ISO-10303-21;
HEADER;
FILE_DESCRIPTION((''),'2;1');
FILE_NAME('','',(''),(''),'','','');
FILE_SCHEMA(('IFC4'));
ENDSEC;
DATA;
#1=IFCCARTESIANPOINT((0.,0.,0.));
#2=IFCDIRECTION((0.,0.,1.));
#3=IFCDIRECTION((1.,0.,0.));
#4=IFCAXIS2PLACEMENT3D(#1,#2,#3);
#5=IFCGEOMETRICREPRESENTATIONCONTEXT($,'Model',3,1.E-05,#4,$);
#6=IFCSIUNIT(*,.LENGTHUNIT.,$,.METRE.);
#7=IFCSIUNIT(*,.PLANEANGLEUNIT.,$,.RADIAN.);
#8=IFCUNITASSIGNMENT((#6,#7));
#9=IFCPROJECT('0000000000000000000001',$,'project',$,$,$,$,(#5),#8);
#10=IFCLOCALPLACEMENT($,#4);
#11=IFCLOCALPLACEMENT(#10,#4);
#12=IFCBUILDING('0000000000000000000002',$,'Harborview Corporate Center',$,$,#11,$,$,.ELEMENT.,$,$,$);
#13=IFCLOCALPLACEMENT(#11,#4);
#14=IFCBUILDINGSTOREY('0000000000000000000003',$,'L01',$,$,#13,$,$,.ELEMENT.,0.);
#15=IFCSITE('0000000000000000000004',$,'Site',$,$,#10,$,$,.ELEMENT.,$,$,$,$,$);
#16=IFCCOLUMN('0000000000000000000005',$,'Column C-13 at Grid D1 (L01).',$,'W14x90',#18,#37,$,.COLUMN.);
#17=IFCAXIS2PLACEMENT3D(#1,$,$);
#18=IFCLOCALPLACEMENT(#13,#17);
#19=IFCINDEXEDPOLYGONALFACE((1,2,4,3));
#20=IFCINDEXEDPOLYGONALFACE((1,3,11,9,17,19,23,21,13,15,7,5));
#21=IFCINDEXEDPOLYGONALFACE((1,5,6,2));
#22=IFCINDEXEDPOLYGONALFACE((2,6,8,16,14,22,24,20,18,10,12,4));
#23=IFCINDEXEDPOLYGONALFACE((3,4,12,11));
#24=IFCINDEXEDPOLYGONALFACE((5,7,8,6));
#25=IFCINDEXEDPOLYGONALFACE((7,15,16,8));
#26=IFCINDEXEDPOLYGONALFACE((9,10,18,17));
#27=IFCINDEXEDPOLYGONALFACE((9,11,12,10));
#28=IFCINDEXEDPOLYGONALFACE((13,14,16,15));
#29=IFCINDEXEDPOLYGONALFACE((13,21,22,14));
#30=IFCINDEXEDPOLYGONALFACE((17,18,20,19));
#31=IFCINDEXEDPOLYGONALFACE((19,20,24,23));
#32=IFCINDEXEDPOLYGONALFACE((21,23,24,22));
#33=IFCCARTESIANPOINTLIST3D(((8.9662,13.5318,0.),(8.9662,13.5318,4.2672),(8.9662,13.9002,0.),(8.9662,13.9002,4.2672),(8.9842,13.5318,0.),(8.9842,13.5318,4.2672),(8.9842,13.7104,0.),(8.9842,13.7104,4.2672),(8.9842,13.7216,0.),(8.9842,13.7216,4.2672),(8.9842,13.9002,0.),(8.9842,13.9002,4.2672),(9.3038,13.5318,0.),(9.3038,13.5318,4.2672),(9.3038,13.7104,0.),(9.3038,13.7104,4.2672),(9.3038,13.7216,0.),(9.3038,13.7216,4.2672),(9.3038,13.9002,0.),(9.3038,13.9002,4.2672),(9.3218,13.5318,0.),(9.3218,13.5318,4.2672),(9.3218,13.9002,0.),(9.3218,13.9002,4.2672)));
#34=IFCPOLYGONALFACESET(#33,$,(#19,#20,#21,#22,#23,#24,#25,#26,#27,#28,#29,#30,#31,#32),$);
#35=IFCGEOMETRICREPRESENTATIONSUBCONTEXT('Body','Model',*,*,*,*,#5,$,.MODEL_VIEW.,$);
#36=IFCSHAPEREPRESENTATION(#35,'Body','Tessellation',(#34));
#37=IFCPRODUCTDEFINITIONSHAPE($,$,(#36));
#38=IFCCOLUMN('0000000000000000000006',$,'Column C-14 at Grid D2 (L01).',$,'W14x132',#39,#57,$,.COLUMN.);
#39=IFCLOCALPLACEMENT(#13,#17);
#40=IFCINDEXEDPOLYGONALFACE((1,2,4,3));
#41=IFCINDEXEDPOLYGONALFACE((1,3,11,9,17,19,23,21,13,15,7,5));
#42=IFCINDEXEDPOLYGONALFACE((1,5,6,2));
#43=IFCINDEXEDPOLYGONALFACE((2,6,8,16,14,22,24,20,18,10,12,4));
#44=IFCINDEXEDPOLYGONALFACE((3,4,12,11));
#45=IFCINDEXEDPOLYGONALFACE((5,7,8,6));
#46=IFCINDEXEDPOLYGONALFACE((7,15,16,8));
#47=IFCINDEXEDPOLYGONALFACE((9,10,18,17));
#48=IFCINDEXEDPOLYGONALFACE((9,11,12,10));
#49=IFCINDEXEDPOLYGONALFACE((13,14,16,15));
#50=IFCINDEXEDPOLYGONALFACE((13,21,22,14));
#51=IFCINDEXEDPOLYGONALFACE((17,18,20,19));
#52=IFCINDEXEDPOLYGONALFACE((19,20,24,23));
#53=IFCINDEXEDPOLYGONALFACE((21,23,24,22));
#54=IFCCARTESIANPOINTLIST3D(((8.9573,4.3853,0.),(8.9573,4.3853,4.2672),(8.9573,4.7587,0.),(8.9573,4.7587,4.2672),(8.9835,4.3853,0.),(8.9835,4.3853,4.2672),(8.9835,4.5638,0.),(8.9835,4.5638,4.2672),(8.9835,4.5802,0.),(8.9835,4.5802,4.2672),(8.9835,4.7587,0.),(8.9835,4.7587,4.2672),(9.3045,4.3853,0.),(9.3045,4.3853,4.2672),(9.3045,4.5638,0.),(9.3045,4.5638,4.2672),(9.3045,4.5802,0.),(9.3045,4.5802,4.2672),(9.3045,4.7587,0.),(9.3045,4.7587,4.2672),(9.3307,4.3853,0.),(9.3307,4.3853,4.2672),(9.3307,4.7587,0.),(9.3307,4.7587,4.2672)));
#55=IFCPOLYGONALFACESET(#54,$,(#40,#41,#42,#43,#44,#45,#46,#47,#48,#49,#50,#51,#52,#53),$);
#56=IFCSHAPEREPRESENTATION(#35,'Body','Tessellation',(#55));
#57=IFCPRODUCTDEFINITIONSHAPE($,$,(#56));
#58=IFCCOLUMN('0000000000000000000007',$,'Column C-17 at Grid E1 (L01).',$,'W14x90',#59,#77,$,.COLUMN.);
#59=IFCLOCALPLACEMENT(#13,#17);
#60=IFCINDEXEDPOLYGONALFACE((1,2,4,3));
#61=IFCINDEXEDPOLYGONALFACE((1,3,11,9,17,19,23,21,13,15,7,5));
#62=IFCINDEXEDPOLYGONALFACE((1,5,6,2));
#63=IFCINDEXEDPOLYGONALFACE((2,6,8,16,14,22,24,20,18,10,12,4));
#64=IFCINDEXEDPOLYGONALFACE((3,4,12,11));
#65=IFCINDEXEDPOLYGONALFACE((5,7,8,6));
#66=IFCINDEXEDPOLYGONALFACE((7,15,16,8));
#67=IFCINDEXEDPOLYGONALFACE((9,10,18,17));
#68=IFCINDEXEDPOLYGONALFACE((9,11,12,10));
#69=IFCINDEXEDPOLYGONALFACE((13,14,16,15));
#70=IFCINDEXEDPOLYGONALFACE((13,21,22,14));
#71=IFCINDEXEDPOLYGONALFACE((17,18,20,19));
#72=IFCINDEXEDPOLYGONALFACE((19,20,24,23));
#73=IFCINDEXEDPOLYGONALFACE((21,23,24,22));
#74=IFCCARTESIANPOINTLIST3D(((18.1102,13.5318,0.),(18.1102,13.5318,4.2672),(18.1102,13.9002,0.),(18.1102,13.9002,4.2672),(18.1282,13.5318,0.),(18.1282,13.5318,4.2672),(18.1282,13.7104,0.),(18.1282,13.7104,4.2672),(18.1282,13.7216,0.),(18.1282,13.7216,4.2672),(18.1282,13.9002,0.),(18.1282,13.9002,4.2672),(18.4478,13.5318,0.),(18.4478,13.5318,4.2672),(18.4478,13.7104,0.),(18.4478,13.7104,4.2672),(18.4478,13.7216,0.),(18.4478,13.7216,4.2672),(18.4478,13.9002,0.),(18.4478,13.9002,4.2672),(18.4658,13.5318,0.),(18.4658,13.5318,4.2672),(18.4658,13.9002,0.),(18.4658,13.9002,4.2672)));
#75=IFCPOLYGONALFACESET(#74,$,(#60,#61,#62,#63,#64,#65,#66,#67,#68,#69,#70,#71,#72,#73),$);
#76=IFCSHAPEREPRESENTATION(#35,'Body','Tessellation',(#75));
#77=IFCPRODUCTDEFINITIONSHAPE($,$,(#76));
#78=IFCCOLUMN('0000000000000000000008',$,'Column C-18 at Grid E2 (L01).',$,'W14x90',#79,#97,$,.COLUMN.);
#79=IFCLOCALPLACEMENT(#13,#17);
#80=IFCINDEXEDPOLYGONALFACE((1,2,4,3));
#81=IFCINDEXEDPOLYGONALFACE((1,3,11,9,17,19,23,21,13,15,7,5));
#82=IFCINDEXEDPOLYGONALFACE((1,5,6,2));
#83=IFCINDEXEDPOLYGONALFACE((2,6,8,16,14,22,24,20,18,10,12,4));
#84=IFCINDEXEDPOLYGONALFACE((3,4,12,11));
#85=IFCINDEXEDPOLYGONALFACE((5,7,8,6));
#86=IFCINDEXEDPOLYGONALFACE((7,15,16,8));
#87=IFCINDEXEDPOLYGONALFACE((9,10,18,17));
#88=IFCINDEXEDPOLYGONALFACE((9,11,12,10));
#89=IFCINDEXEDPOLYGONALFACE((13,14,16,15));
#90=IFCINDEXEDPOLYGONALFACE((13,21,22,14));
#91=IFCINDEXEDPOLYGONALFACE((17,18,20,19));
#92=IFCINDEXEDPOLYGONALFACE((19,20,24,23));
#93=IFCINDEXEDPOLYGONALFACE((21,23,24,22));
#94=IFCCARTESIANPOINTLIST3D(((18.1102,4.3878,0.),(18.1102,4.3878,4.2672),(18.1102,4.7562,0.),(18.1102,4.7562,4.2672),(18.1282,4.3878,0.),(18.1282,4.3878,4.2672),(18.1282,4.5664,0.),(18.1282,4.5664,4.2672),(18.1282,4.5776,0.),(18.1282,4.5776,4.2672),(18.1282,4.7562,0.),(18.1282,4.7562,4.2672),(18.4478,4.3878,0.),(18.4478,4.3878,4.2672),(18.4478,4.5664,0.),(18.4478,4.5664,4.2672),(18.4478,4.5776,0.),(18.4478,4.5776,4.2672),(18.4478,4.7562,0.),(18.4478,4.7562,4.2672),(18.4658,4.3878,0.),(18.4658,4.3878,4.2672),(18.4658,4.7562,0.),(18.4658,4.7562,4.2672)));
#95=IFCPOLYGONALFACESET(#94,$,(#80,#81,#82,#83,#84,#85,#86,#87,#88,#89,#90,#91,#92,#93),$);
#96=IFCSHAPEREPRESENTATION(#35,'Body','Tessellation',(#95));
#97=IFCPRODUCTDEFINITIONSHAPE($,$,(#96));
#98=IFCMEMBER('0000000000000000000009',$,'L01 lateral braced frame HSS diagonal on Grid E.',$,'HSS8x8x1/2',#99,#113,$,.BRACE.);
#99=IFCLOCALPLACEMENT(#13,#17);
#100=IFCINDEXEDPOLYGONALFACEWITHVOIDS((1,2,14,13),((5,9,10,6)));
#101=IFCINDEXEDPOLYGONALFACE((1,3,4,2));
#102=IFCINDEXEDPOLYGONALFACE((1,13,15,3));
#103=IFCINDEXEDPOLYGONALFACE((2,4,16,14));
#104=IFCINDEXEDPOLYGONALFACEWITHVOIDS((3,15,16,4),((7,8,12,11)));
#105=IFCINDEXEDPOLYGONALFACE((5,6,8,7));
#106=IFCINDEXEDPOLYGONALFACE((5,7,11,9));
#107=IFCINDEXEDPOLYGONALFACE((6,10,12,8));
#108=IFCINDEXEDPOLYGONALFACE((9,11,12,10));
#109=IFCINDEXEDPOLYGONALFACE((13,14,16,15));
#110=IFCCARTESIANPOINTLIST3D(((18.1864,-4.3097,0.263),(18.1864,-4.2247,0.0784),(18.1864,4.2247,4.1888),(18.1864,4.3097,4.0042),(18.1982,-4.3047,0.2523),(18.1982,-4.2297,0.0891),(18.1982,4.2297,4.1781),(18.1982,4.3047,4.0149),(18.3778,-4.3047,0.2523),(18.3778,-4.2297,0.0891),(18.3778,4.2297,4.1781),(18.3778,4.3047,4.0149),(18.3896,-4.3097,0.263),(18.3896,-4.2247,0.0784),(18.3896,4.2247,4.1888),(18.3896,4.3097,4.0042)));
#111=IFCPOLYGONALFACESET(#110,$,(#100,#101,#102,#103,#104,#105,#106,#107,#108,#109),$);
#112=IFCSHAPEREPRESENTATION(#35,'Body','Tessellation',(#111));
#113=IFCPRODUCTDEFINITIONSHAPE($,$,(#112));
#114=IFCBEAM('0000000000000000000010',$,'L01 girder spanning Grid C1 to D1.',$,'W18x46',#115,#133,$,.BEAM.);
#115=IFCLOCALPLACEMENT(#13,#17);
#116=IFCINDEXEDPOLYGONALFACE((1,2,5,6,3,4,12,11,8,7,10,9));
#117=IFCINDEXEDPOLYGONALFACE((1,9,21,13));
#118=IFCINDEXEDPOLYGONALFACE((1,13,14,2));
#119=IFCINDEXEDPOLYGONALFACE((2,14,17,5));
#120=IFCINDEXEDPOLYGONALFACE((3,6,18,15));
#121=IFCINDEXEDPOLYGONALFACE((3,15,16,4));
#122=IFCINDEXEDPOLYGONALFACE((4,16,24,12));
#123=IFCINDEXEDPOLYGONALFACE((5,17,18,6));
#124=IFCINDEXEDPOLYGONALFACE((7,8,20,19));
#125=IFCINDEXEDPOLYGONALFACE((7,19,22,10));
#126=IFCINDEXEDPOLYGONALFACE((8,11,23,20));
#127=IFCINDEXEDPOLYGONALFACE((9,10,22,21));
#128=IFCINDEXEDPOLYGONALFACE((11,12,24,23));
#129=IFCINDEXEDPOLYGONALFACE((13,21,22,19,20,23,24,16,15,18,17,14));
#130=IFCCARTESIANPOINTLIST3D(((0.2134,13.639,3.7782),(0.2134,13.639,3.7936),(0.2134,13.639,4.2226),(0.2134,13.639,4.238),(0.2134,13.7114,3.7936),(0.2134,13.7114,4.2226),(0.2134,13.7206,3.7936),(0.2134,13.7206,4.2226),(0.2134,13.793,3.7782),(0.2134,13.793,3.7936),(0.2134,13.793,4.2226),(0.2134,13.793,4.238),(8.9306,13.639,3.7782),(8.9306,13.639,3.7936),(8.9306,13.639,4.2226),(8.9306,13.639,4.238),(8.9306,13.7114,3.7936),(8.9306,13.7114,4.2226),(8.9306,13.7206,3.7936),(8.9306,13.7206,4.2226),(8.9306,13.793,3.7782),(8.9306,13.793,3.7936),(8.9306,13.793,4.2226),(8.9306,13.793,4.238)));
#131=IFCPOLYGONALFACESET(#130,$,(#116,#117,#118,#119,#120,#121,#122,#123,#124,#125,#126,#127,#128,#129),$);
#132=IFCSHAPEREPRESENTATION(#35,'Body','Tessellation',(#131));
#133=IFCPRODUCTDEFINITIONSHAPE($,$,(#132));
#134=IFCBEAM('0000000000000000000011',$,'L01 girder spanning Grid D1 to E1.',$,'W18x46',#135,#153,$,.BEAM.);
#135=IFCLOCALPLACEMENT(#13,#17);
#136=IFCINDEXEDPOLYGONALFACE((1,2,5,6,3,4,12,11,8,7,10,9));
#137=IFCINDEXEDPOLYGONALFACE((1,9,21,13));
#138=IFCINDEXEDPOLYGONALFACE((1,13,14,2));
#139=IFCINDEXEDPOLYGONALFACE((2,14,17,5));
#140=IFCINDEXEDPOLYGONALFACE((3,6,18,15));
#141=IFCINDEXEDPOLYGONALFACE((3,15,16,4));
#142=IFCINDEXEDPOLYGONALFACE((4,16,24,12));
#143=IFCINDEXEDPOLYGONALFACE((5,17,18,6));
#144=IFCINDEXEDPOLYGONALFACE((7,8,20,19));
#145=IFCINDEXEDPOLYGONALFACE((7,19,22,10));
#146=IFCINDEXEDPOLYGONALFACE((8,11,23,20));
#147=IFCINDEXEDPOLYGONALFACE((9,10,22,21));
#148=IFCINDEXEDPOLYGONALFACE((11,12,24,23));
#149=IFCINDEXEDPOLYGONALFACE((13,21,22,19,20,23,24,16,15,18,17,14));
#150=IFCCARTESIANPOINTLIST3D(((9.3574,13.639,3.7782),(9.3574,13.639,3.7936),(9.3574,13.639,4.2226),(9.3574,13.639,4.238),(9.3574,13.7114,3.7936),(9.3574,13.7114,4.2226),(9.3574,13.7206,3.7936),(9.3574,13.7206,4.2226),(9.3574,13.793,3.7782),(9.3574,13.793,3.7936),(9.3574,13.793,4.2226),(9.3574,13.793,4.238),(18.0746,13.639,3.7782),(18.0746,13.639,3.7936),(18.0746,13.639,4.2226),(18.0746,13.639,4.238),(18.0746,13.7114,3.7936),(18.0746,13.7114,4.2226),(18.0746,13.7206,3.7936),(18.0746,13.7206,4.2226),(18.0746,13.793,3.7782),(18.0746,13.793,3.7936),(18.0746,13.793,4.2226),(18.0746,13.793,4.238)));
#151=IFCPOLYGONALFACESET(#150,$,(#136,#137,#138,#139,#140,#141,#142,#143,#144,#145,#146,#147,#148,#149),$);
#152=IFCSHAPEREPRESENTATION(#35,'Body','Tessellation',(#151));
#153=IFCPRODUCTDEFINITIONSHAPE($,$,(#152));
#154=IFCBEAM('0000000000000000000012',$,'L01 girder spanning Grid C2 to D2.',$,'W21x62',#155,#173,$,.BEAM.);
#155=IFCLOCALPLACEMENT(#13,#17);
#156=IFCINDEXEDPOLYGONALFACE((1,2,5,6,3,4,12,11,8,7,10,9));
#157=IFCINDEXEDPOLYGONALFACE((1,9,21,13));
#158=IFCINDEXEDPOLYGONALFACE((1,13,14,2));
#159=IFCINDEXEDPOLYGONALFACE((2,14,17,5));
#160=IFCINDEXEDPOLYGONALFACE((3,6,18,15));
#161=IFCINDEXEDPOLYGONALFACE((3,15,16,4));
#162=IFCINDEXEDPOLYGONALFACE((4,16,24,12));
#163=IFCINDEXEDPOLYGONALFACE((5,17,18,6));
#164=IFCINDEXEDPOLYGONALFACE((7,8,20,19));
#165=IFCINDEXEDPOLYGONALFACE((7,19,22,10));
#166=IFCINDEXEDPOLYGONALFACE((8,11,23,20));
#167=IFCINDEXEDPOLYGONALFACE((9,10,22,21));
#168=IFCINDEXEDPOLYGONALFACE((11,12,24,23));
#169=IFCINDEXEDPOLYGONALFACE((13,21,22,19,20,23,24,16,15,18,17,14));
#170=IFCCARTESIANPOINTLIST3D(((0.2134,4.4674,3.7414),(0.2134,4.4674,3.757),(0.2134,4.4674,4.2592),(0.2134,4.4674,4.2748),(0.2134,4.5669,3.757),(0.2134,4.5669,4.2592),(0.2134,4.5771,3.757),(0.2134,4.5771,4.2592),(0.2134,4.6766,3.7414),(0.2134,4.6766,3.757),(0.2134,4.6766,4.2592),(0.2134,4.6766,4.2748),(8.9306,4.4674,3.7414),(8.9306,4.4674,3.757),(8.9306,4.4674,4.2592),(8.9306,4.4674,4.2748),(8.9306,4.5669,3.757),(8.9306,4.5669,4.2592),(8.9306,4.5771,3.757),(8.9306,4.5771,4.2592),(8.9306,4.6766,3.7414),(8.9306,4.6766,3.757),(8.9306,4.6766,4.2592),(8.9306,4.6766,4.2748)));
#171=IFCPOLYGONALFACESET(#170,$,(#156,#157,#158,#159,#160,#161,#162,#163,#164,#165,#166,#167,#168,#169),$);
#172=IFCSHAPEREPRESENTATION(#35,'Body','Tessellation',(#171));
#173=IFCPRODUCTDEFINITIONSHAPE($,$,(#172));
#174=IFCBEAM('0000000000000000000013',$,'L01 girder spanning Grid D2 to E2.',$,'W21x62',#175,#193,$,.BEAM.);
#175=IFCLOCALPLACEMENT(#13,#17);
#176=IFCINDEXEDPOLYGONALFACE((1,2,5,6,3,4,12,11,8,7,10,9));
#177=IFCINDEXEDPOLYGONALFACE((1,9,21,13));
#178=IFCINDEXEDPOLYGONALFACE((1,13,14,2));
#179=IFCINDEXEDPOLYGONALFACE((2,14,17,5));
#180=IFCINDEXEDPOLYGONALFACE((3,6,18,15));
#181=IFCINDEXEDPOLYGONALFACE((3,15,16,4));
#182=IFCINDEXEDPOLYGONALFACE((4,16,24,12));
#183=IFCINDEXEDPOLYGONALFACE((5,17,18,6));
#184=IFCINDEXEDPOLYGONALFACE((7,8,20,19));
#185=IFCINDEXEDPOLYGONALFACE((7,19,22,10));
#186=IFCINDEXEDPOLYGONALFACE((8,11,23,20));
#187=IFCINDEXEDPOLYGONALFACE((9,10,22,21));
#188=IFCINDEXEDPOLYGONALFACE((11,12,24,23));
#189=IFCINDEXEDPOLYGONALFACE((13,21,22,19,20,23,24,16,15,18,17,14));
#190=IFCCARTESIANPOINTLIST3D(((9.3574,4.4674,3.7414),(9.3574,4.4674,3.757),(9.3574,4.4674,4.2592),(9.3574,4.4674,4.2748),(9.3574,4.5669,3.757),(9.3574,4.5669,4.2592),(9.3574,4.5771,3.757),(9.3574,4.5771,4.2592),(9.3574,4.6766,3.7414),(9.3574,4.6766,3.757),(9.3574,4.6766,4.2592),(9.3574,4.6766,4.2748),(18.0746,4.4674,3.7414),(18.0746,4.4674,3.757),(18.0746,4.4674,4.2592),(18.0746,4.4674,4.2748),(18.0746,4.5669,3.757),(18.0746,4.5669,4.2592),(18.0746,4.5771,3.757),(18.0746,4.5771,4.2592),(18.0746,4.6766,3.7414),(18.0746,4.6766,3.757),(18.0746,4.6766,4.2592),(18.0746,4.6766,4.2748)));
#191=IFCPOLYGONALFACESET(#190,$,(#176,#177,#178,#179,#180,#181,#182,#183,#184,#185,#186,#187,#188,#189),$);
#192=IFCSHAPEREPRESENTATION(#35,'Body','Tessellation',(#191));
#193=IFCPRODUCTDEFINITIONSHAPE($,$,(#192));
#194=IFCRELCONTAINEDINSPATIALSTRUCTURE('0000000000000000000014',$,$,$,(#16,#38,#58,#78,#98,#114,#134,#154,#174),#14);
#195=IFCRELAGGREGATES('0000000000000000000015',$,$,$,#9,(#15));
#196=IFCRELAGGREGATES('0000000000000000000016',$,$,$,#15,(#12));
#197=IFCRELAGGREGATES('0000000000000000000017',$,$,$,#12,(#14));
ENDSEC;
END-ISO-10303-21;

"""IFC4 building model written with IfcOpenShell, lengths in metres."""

from ifc_helpers import new_model, si_unit, frame, origin_with_axes, place, context, subcontext, project, spatial, hollow_rectangle, i_section, extrude, element, save


model = new_model("IFC4")

# Units and contexts
model_context = context("Model", 3, precision=1e-05, world=origin_with_axes())
body_context = subcontext(model_context, "Body", "Model", "MODEL_VIEW")
ifc_project = project(units=[si_unit("LENGTHUNIT", "METRE"), si_unit("PLANEANGLEUNIT", "RADIAN")], contexts=[model_context])

# Site, building, storey
site_placement = place(None, origin_with_axes())
site = spatial("IfcSite", under=ifc_project, at=site_placement, Name="Site", CompositionType="ELEMENT")
building_placement = place(site_placement, origin_with_axes())
building = spatial("IfcBuilding", under=site, at=building_placement, Name="Harborview Corporate Center", CompositionType="ELEMENT")
storey_placement = place(building_placement, origin_with_axes())
storey = spatial("IfcBuildingStorey", under=building, at=storey_placement, Name="L01", CompositionType="ELEMENT", Elevation=0.0)

# Columns
column_1_placement = place(storey_placement, frame((9.144, 13.716, 0.0), z_axis=(0.0, 0.0, 1.0), x_axis=(0.0, 1.0, 0.0)))
element("IfcColumn", 1, at=column_1_placement, inside=storey, Name="Column C-13 at Grid D1 (L01).", ObjectType="W14x90", PredefinedType="COLUMN", context=body_context, shape_type="SweptSolid", body=[
    extrude(i_section(OverallWidth=0.3683, OverallDepth=0.3556, WebThickness=0.0112, FlangeThickness=0.018), origin_with_axes(), (0.0, 0.0, 1.0), 4.2672),
])
column_2_placement = place(storey_placement, frame((9.144, 4.572, 0.0), z_axis=(0.0, 0.0, 1.0), x_axis=(0.0, 1.0, 0.0)))
element("IfcColumn", 2, at=column_2_placement, inside=storey, Name="Column C-14 at Grid D2 (L01).", ObjectType="W14x132", PredefinedType="COLUMN", context=body_context, shape_type="SweptSolid", body=[
    extrude(i_section(OverallWidth=0.3734, OverallDepth=0.3734, WebThickness=0.0164, FlangeThickness=0.0262), origin_with_axes(), (0.0, 0.0, 1.0), 4.2672),
])
for number, where, z_axis, x_axis, name in (
    (3, (18.288, 13.716, 0.0), (0.0, 0.0, 1.0), (0.0, 1.0, 0.0), "Column C-17 at Grid E1 (L01)."),
    (4, (18.288, 4.572, 0.0), (0.0, 0.0, 1.0), (0.0, 1.0, 0.0), "Column C-18 at Grid E2 (L01)."),
):
    element("IfcColumn", number, at=place(storey_placement, frame(where, z_axis=z_axis, x_axis=x_axis)), inside=storey, Name=name, ObjectType="W14x90", PredefinedType="COLUMN", context=body_context, shape_type="SweptSolid", body=[
        extrude(i_section(OverallWidth=0.3683, OverallDepth=0.3556, WebThickness=0.0112, FlangeThickness=0.018), origin_with_axes(), (0.0, 0.0, 1.0), 4.2672),
    ])

# Member
member_placement = place(storey_placement, frame((18.288, -4.2672, 0.1707), z_axis=(0.0, 0.90849, 0.417906), x_axis=(-1.0, 0.0, 0.0)))
element("IfcMember", 5, at=member_placement, inside=storey, Name="L01 lateral braced frame HSS diagonal on Grid E.", ObjectType="HSS8x8x1/2", PredefinedType="BRACE", context=body_context, shape_type="SweptSolid", body=[
    extrude(hollow_rectangle(XDim=0.2032, YDim=0.2032, WallThickness=0.0118), origin_with_axes(), (0.0, 0.0, 1.0), 9.394),
])

# Beams
beam_1_placement = place(storey_placement, frame((0.2134, 13.716, 4.0081), z_axis=(1.0, 0.0, 0.0), x_axis=(0.0, 1.0, 0.0)))
element("IfcBeam", 6, at=beam_1_placement, inside=storey, Name="L01 girder spanning Grid C1 to D1.", ObjectType="W18x46", PredefinedType="BEAM", context=body_context, shape_type="SweptSolid", body=[
    extrude(i_section(OverallWidth=0.1539, OverallDepth=0.4597, WebThickness=0.0091, FlangeThickness=0.0154), origin_with_axes(), (0.0, 0.0, 1.0), 8.7173),
])
beam_2_placement = place(storey_placement, frame((9.3574, 13.716, 4.0081), z_axis=(1.0, 0.0, 0.0), x_axis=(0.0, 1.0, 0.0)))
element("IfcBeam", 7, at=beam_2_placement, inside=storey, Name="L01 girder spanning Grid D1 to E1.", ObjectType="W18x46", PredefinedType="BEAM", context=body_context, shape_type="SweptSolid", body=[
    extrude(i_section(OverallWidth=0.1539, OverallDepth=0.4597, WebThickness=0.0091, FlangeThickness=0.0154), origin_with_axes(), (0.0, 0.0, 1.0), 8.7173),
])
beam_3_placement = place(storey_placement, frame((0.2134, 4.572, 4.0081), z_axis=(1.0, 0.0, 0.0), x_axis=(0.0, 1.0, 0.0)))
element("IfcBeam", 8, at=beam_3_placement, inside=storey, Name="L01 girder spanning Grid C2 to D2.", ObjectType="W21x62", PredefinedType="BEAM", context=body_context, shape_type="SweptSolid", body=[
    extrude(i_section(OverallWidth=0.2093, OverallDepth=0.5334, WebThickness=0.0102, FlangeThickness=0.0156), origin_with_axes(), (0.0, 0.0, 1.0), 8.7173),
])
beam_4_placement = place(storey_placement, frame((9.3574, 4.572, 4.0081), z_axis=(1.0, 0.0, 0.0), x_axis=(0.0, 1.0, 0.0)))
element("IfcBeam", 9, at=beam_4_placement, inside=storey, Name="L01 girder spanning Grid D2 to E2.", ObjectType="W21x62", PredefinedType="BEAM", context=body_context, shape_type="SweptSolid", body=[
    extrude(i_section(OverallWidth=0.2093, OverallDepth=0.5334, WebThickness=0.0102, FlangeThickness=0.0156), origin_with_axes(), (0.0, 0.0, 1.0), 8.7173),
])

save(model, "model.ifc")
